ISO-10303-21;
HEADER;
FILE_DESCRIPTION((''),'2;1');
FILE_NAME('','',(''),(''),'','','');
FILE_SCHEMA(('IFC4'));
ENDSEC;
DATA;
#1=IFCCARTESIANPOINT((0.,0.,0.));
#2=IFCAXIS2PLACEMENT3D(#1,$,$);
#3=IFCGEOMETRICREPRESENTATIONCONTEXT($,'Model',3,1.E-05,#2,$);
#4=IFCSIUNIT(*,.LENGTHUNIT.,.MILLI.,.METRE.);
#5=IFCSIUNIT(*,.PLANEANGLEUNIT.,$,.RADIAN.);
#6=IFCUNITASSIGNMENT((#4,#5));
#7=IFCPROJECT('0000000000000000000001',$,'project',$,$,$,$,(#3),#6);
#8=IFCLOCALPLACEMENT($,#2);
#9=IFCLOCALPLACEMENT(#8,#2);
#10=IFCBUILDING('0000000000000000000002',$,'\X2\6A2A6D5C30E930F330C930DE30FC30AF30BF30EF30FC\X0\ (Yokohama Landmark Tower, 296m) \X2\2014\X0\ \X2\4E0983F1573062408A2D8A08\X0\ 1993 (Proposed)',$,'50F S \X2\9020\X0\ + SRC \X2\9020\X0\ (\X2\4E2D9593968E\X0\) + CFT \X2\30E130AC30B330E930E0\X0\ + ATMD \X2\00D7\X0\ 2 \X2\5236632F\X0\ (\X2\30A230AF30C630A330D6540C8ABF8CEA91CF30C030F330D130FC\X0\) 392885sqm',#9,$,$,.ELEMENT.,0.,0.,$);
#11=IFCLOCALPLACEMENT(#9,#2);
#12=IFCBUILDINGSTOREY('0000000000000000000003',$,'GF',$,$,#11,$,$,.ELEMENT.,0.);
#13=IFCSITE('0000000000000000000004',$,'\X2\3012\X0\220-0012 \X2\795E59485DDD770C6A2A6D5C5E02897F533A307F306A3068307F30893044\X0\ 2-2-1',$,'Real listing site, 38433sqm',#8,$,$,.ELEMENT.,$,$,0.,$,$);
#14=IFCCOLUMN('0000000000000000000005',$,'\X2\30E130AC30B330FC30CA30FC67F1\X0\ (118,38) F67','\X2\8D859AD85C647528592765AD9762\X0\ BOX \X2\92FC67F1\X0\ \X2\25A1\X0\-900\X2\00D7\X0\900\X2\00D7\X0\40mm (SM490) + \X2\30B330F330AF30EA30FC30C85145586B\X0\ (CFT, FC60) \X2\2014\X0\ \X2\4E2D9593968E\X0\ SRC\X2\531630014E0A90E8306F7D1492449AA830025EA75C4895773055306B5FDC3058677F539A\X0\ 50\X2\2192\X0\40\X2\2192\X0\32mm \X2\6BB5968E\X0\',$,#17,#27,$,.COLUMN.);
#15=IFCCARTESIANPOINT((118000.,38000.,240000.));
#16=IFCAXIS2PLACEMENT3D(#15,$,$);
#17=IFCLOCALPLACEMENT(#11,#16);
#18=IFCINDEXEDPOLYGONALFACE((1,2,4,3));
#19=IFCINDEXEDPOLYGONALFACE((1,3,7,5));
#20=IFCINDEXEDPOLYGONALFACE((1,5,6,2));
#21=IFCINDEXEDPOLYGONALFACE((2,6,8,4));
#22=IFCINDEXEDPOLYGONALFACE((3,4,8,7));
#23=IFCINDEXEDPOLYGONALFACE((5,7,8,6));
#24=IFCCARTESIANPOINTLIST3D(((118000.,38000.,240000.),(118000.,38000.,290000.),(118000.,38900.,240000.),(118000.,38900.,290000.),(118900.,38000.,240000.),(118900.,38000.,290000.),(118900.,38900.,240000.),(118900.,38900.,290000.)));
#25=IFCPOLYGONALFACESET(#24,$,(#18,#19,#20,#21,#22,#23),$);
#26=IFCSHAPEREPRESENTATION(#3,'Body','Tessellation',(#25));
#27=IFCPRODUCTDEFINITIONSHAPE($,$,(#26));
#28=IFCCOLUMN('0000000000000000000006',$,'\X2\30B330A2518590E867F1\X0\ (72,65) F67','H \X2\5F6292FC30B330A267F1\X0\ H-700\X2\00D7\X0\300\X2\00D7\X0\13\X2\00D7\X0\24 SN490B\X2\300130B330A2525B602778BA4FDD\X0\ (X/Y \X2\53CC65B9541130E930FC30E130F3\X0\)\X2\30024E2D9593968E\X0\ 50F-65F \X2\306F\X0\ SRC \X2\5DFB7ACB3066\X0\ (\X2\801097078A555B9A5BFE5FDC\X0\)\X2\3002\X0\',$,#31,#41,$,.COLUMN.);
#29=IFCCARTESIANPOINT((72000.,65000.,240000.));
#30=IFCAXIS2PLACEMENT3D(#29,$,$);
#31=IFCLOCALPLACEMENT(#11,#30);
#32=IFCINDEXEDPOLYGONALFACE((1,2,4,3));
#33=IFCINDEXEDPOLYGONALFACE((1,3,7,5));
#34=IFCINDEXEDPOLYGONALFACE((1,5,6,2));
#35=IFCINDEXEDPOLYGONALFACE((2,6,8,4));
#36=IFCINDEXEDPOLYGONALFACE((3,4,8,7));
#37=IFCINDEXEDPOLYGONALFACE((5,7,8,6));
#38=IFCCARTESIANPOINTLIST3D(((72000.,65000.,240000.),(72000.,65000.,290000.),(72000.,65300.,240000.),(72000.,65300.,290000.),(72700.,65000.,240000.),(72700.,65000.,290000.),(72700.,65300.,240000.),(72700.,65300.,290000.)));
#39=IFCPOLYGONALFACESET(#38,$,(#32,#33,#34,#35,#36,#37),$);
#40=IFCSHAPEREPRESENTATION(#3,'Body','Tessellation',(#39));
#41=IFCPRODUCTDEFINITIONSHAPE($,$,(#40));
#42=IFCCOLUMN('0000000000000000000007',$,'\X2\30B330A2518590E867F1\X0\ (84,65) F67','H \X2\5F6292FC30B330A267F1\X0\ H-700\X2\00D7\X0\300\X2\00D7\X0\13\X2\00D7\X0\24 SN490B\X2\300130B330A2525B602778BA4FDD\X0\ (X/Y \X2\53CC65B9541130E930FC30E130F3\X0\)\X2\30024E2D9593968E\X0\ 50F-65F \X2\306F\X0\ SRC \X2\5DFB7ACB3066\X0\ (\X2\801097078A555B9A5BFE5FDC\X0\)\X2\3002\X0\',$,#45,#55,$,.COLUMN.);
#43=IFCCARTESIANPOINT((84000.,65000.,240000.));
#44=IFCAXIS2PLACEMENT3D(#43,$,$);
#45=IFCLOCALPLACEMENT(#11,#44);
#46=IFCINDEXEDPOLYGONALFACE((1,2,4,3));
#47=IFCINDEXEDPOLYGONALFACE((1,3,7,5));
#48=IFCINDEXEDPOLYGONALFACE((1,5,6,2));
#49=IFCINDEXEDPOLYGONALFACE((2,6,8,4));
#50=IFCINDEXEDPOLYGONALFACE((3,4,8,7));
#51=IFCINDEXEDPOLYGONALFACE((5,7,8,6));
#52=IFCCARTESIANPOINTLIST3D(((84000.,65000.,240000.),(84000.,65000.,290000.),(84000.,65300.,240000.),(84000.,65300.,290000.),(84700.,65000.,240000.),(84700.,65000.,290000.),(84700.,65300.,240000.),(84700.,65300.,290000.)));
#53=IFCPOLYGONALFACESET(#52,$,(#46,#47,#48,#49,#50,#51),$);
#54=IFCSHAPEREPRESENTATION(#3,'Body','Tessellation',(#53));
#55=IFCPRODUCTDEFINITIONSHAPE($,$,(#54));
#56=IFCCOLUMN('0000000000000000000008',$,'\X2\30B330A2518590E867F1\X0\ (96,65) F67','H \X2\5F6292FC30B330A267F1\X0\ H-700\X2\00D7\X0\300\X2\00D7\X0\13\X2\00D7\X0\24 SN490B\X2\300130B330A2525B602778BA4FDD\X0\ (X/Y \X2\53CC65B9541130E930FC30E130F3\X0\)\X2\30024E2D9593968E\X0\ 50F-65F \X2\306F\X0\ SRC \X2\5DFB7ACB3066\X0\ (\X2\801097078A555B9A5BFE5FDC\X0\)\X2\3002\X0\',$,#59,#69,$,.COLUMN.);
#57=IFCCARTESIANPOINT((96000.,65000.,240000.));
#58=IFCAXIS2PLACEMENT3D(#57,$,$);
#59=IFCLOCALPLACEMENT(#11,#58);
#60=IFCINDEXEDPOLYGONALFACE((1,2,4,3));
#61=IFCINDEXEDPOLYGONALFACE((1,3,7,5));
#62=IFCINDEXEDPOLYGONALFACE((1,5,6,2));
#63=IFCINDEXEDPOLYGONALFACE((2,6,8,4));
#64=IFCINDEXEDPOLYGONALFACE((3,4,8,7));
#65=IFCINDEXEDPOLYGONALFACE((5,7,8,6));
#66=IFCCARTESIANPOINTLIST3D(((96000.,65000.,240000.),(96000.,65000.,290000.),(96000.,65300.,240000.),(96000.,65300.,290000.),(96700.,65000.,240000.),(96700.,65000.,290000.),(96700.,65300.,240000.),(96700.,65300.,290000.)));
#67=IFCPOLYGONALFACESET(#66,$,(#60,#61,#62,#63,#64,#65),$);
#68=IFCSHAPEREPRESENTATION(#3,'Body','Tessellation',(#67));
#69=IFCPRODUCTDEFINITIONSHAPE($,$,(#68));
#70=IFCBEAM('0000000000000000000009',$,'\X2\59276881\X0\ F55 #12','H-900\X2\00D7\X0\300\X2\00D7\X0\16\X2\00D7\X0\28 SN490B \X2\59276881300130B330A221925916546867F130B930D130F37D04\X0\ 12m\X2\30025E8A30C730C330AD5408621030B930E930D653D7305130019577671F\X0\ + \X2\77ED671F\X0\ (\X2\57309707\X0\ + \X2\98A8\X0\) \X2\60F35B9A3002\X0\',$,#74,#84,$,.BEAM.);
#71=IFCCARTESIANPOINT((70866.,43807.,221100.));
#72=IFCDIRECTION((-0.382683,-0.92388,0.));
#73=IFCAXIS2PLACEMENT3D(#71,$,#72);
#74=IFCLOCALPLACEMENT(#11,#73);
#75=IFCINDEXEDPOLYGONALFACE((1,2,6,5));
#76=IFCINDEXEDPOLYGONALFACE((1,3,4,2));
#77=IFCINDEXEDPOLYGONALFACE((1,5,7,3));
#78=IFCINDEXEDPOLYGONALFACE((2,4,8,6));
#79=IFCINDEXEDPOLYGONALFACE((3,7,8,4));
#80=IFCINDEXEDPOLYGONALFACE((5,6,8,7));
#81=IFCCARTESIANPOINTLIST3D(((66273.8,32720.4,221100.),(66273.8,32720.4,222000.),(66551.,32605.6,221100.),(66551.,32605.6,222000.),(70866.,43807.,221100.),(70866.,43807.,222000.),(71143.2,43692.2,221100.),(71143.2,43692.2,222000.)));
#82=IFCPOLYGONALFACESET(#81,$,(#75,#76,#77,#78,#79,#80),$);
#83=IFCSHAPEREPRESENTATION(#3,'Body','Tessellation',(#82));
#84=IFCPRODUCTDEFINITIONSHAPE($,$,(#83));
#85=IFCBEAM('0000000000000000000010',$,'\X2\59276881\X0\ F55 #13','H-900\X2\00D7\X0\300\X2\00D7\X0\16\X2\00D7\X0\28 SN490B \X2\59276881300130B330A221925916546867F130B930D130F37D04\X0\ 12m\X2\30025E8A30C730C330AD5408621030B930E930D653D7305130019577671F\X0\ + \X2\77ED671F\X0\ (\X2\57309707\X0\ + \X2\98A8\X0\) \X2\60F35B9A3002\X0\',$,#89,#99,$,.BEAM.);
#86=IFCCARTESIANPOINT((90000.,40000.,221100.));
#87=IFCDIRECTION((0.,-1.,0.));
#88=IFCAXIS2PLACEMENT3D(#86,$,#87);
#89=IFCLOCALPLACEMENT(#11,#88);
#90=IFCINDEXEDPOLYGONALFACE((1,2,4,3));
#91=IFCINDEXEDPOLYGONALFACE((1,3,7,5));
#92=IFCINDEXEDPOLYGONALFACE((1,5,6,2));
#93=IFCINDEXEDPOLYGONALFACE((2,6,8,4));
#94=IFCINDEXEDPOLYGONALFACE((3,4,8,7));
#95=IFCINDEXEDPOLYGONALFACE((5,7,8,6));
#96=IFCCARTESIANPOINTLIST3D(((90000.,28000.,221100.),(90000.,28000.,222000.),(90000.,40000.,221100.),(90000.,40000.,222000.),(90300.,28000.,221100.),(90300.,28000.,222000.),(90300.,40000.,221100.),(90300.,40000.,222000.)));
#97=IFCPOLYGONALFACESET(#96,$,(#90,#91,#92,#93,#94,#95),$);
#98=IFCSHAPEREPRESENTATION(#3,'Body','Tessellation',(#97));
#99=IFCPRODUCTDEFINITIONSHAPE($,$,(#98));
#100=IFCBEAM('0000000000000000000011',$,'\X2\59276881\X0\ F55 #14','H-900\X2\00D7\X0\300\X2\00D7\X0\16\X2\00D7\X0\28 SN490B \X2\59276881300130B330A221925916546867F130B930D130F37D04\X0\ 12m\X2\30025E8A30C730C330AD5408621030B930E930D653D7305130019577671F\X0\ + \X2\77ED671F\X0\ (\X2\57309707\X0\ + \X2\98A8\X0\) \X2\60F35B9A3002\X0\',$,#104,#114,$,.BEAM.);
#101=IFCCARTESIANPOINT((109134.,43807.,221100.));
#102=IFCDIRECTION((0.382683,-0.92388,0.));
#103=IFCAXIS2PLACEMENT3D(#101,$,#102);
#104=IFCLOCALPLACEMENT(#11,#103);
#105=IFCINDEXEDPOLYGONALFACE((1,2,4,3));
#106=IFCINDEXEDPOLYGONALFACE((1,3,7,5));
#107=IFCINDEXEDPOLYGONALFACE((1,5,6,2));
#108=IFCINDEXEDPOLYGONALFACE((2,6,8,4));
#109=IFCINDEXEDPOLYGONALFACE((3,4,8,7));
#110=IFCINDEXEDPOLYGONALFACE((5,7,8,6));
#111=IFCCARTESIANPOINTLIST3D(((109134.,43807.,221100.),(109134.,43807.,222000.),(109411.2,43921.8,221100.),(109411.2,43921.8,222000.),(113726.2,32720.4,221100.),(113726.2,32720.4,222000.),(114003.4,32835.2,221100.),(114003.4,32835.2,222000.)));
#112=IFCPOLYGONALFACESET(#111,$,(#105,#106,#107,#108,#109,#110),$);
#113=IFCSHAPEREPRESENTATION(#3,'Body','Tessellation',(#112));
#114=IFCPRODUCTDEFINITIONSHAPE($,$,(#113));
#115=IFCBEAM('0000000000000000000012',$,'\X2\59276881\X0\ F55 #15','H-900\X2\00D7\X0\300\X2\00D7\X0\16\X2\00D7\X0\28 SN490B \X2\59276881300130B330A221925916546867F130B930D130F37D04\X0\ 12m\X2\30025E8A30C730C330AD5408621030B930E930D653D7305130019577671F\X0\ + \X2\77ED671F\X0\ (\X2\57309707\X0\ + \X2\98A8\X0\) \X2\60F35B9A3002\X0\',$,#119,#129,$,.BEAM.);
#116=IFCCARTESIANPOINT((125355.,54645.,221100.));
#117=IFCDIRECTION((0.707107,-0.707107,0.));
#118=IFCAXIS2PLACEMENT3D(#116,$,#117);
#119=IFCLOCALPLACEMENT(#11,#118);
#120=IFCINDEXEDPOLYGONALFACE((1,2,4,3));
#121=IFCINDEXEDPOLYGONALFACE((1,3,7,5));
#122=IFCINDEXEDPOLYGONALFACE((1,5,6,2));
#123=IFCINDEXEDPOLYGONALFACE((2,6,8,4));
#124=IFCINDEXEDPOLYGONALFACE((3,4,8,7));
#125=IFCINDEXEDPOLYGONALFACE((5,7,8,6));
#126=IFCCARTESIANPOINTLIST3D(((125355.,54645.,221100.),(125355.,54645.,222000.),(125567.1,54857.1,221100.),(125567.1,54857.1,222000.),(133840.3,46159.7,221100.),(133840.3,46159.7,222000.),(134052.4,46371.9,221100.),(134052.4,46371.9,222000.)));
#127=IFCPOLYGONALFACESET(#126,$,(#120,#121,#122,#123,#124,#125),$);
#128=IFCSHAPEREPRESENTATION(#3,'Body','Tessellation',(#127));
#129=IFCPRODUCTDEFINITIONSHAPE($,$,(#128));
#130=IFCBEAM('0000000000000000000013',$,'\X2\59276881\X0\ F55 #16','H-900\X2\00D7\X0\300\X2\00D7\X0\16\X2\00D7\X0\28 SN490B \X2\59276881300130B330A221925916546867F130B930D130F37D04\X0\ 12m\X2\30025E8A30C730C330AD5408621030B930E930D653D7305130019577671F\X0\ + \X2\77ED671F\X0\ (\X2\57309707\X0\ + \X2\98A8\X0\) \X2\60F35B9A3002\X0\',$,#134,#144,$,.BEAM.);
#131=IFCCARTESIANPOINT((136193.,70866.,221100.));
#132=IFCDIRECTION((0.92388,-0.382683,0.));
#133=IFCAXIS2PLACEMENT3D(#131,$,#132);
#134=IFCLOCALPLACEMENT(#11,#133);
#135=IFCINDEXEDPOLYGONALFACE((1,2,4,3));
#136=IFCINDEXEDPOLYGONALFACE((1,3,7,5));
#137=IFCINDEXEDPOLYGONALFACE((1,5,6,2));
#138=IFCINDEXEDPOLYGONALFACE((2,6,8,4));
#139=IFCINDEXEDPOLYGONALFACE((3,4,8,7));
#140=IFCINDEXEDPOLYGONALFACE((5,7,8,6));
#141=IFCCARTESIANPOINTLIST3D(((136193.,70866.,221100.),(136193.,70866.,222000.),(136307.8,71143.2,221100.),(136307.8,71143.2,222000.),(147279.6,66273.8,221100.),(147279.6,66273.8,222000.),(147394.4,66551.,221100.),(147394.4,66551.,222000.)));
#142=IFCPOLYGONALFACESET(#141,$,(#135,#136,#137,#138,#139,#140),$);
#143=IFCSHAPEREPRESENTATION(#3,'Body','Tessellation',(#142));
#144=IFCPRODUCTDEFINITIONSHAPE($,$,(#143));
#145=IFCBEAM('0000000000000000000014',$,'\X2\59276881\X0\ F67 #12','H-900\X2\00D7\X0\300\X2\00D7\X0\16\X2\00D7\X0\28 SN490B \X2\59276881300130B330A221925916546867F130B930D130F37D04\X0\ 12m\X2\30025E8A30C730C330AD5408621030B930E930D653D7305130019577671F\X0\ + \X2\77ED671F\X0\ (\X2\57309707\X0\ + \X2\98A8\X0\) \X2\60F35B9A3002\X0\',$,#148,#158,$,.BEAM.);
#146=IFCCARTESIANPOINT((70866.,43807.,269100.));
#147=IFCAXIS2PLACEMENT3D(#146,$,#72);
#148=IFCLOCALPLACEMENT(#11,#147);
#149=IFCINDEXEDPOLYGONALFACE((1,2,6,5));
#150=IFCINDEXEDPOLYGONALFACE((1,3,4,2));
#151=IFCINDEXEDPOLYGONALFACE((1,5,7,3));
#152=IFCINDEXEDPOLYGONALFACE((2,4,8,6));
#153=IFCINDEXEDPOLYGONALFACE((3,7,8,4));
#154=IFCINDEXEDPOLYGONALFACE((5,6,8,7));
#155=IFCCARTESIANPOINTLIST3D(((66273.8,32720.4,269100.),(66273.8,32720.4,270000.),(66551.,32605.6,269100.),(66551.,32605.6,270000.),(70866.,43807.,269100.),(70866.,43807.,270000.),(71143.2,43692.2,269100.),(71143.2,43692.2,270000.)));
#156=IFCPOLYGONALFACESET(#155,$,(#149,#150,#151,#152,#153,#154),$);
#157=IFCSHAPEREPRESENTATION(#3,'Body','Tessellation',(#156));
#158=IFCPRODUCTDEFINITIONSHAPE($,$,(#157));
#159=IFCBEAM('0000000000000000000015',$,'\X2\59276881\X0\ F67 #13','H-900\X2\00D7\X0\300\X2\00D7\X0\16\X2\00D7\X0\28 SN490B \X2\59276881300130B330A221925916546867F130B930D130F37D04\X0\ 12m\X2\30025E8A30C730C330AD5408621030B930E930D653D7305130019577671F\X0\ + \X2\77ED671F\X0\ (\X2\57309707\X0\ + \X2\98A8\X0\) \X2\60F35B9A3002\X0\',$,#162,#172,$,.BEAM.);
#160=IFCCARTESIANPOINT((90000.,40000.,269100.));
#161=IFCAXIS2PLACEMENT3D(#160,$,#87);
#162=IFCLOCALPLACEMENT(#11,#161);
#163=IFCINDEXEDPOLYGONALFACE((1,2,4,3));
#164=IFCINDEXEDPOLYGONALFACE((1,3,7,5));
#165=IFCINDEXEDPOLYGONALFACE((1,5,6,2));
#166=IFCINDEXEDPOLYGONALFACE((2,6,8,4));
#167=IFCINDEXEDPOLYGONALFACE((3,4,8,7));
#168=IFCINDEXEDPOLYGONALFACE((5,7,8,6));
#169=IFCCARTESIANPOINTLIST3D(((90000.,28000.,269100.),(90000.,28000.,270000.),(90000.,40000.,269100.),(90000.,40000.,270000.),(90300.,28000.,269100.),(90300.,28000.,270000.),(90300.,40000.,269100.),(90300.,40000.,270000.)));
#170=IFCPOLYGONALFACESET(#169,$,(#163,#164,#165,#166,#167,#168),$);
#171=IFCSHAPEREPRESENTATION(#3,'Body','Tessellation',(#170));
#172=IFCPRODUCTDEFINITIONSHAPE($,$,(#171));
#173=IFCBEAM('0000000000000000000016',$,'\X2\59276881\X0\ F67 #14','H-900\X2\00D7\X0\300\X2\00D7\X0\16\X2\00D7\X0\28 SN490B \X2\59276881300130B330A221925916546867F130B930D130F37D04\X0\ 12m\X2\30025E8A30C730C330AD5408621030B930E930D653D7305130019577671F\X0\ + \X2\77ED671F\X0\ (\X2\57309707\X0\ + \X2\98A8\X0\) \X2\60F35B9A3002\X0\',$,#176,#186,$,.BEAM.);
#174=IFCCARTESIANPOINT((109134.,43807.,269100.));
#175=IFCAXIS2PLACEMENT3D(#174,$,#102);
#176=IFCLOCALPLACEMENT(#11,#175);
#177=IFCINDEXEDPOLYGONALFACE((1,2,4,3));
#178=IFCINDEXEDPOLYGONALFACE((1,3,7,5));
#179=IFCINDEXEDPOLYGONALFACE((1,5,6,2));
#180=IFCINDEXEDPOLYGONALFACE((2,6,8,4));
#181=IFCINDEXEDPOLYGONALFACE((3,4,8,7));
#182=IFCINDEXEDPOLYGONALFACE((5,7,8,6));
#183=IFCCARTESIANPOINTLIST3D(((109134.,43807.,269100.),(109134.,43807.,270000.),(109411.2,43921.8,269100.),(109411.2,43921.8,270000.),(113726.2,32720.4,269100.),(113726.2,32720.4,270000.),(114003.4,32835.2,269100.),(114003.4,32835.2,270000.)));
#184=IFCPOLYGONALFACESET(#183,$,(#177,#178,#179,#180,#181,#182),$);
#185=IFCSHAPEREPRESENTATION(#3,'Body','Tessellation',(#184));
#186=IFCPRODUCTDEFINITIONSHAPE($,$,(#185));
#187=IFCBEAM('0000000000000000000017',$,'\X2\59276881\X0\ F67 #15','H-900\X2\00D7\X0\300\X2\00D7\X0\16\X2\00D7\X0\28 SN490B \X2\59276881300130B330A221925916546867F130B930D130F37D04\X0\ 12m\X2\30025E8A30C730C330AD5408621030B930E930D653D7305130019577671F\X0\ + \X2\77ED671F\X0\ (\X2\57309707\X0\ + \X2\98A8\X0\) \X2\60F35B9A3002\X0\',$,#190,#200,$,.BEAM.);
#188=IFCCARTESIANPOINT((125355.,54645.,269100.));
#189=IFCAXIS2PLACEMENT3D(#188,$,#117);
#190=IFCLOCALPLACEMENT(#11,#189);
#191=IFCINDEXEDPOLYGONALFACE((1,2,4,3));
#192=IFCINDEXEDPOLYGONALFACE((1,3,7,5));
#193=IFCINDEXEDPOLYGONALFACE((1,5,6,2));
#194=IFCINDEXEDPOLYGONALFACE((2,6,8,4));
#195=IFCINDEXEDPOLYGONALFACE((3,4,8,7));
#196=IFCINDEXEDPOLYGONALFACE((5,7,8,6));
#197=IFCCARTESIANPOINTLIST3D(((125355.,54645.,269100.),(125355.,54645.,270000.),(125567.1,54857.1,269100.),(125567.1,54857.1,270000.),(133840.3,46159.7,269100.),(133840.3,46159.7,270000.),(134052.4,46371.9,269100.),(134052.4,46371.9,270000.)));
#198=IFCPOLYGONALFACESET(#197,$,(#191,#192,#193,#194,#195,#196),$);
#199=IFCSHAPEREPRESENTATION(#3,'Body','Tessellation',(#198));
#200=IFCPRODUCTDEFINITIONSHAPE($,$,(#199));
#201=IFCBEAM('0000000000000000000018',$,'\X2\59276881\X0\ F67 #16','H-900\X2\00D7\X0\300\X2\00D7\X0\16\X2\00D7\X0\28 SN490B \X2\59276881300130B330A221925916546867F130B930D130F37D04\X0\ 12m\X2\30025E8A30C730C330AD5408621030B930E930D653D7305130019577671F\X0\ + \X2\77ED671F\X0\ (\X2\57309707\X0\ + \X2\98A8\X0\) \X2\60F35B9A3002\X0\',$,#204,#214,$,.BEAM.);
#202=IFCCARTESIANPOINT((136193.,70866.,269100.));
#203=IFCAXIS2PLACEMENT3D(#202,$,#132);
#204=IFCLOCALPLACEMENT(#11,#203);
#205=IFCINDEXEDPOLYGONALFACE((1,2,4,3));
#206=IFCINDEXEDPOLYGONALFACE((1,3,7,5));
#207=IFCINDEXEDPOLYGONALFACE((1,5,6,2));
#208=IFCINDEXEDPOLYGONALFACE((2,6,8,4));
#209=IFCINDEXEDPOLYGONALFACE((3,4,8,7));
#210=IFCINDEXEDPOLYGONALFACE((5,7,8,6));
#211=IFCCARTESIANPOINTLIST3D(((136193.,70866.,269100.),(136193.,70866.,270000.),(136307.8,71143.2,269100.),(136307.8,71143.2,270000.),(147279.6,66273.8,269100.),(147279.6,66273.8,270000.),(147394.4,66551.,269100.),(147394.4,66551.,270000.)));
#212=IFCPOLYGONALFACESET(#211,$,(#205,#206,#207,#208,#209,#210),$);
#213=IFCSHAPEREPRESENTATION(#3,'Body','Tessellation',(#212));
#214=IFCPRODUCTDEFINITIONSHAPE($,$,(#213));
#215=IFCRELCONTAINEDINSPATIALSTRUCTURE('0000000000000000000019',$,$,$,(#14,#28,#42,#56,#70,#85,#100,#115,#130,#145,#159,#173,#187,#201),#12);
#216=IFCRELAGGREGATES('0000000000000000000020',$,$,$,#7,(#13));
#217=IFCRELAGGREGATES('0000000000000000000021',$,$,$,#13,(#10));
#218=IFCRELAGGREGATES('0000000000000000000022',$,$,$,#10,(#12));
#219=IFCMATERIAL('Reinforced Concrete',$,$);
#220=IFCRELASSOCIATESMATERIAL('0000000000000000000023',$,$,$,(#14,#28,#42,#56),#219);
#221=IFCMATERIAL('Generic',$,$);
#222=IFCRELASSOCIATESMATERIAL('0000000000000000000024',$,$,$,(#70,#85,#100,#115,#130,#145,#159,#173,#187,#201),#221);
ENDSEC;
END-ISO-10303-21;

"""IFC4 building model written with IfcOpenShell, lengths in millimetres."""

from ifc_helpers import new_model, si_unit, frame, frame_2d, origin, place, context, project, spatial, rectangle, extrude, material, element, save


model = new_model("IFC4")

# Units and contexts
model_context = context("Model", 3, precision=1e-05, world=origin())
ifc_project = project(units=[si_unit("LENGTHUNIT", "METRE", prefix="MILLI"), si_unit("PLANEANGLEUNIT", "RADIAN")], contexts=[model_context])

# Site, building, storey
site_placement = place(None, origin())
site = spatial("IfcSite", under=ifc_project, at=site_placement, Name="〒220-0012 神奈川県横浜市西区みなとみらい 2-2-1", ObjectType="Real listing site, 38433sqm", CompositionType="ELEMENT", RefElevation=0.0)
building_placement = place(site_placement, origin())
building = spatial("IfcBuilding", under=site, at=building_placement, Name="横浜ランドマークタワー (Yokohama Landmark Tower, 296m) — 三菱地所設計 1993 (Proposed)", ObjectType="50F S 造 + SRC 造 (中間階) + CFT メガコラム + ATMD × 2 制振 (アクティブ同調質量ダンパー) 392885sqm", CompositionType="ELEMENT", ElevationOfRefHeight=0.0, ElevationOfTerrain=0.0)
storey_placement = place(building_placement, origin())
storey = spatial("IfcBuildingStorey", under=building, at=storey_placement, Name="GF", CompositionType="ELEMENT", Elevation=0.0)

# Columns
ifc_material_1 = material(Name="Reinforced Concrete")
column_1_placement = place(storey_placement, frame((118000.0, 38000.0, 240000.0)))
element("IfcColumn", 1, at=column_1_placement, inside=storey, material=ifc_material_1, Name="メガコーナー柱 (118,38) F67", Description="超高層用大断面 BOX 鋼柱 □-900×900×40mm (SM490) + コンクリート充填 (CFT, FC60) — 中間階 SRC化、上部は純鉄骨。座屈長さに応じ板厚 50→40→32mm 段階", PredefinedType="COLUMN", context=model_context, shape_type="SweptSolid", body=[
    extrude(rectangle(XDim=900.0, YDim=900.0, at=frame_2d((450.0, 450.0))), frame((118000.0, 38000.0, 240000.0)), (0.0, 0.0, 1.0), 50000.0),
])
column_2_placement = place(storey_placement, frame((72000.0, 65000.0, 240000.0)))
element("IfcColumn", 2, at=column_2_placement, inside=storey, material=ifc_material_1, Name="コア内部柱 (72,65) F67", Description="H 形鋼コア柱 H-700×300×13×24 SN490B、コア剛性確保 (X/Y 双方向ラーメン)。中間階 50F-65F は SRC 巻立て (耐震評定対応)。", PredefinedType="COLUMN", context=model_context, shape_type="SweptSolid", body=[
    extrude(rectangle(XDim=700.0, YDim=300.0, at=frame_2d((350.0, 150.0))), frame((72000.0, 65000.0, 240000.0)), (0.0, 0.0, 1.0), 50000.0),
])
column_3_placement = place(storey_placement, frame((84000.0, 65000.0, 240000.0)))
element("IfcColumn", 3, at=column_3_placement, inside=storey, material=ifc_material_1, Name="コア内部柱 (84,65) F67", Description="H 形鋼コア柱 H-700×300×13×24 SN490B、コア剛性確保 (X/Y 双方向ラーメン)。中間階 50F-65F は SRC 巻立て (耐震評定対応)。", PredefinedType="COLUMN", context=model_context, shape_type="SweptSolid", body=[
    extrude(rectangle(XDim=700.0, YDim=300.0, at=frame_2d((350.0, 150.0))), frame((84000.0, 65000.0, 240000.0)), (0.0, 0.0, 1.0), 50000.0),
])
column_4_placement = place(storey_placement, frame((96000.0, 65000.0, 240000.0)))
element("IfcColumn", 4, at=column_4_placement, inside=storey, material=ifc_material_1, Name="コア内部柱 (96,65) F67", Description="H 形鋼コア柱 H-700×300×13×24 SN490B、コア剛性確保 (X/Y 双方向ラーメン)。中間階 50F-65F は SRC 巻立て (耐震評定対応)。", PredefinedType="COLUMN", context=model_context, shape_type="SweptSolid", body=[
    extrude(rectangle(XDim=700.0, YDim=300.0, at=frame_2d((350.0, 150.0))), frame((96000.0, 65000.0, 240000.0)), (0.0, 0.0, 1.0), 50000.0),
])

# Beams
ifc_material_2 = material(Name="Generic")
beam_1_placement = place(storey_placement, frame((70866.0, 43807.0, 221100.0), x_axis=(-0.382683, -0.92388, 0.0)))
element("IfcBeam", 5, at=beam_1_placement, inside=storey, material=ifc_material_2, Name="大梁 F55 #12", Description="H-900×300×16×28 SN490B 大梁、コア→外周柱スパン約 12m。床デッキ合成スラブ受け、長期 + 短期 (地震 + 風) 想定。", PredefinedType="BEAM", context=model_context, shape_type="SweptSolid", body=[
    extrude(rectangle(XDim=12000.0, YDim=300.0, at=frame_2d((6000.0, 150.0))), frame((70866.0, 43807.0, 221100.0), x_axis=(-0.382683, -0.92388, 0.0)), (0.0, 0.0, 1.0), 900.0),
])
beam_2_placement = place(storey_placement, frame((90000.0, 40000.0, 221100.0), x_axis=(0.0, -1.0, 0.0)))
element("IfcBeam", 6, at=beam_2_placement, inside=storey, material=ifc_material_2, Name="大梁 F55 #13", Description="H-900×300×16×28 SN490B 大梁、コア→外周柱スパン約 12m。床デッキ合成スラブ受け、長期 + 短期 (地震 + 風) 想定。", PredefinedType="BEAM", context=model_context, shape_type="SweptSolid", body=[
    extrude(rectangle(XDim=12000.0, YDim=300.0, at=frame_2d((6000.0, 150.0))), frame((90000.0, 40000.0, 221100.0), x_axis=(0.0, -1.0, 0.0)), (0.0, 0.0, 1.0), 900.0),
])
beam_3_placement = place(storey_placement, frame((109134.0, 43807.0, 221100.0), x_axis=(0.382683, -0.92388, 0.0)))
element("IfcBeam", 7, at=beam_3_placement, inside=storey, material=ifc_material_2, Name="大梁 F55 #14", Description="H-900×300×16×28 SN490B 大梁、コア→外周柱スパン約 12m。床デッキ合成スラブ受け、長期 + 短期 (地震 + 風) 想定。", PredefinedType="BEAM", context=model_context, shape_type="SweptSolid", body=[
    extrude(rectangle(XDim=12000.0, YDim=300.0, at=frame_2d((6000.0, 150.0))), frame((109134.0, 43807.0, 221100.0), x_axis=(0.382683, -0.92388, 0.0)), (0.0, 0.0, 1.0), 900.0),
])
beam_4_placement = place(storey_placement, frame((125355.0, 54645.0, 221100.0), x_axis=(0.707107, -0.707107, 0.0)))
element("IfcBeam", 8, at=beam_4_placement, inside=storey, material=ifc_material_2, Name="大梁 F55 #15", Description="H-900×300×16×28 SN490B 大梁、コア→外周柱スパン約 12m。床デッキ合成スラブ受け、長期 + 短期 (地震 + 風) 想定。", PredefinedType="BEAM", context=model_context, shape_type="SweptSolid", body=[
    extrude(rectangle(XDim=12000.0, YDim=300.0, at=frame_2d((6000.0, 150.0))), frame((125355.0, 54645.0, 221100.0), x_axis=(0.707107, -0.707107, 0.0)), (0.0, 0.0, 1.0), 900.0),
])
beam_5_placement = place(storey_placement, frame((136193.0, 70866.0, 221100.0), x_axis=(0.92388, -0.382683, 0.0)))
element("IfcBeam", 9, at=beam_5_placement, inside=storey, material=ifc_material_2, Name="大梁 F55 #16", Description="H-900×300×16×28 SN490B 大梁、コア→外周柱スパン約 12m。床デッキ合成スラブ受け、長期 + 短期 (地震 + 風) 想定。", PredefinedType="BEAM", context=model_context, shape_type="SweptSolid", body=[
    extrude(rectangle(XDim=12000.0, YDim=300.0, at=frame_2d((6000.0, 150.0))), frame((136193.0, 70866.0, 221100.0), x_axis=(0.92388, -0.382683, 0.0)), (0.0, 0.0, 1.0), 900.0),
])
beam_6_placement = place(storey_placement, frame((70866.0, 43807.0, 269100.0), x_axis=(-0.382683, -0.92388, 0.0)))
element("IfcBeam", 10, at=beam_6_placement, inside=storey, material=ifc_material_2, Name="大梁 F67 #12", Description="H-900×300×16×28 SN490B 大梁、コア→外周柱スパン約 12m。床デッキ合成スラブ受け、長期 + 短期 (地震 + 風) 想定。", PredefinedType="BEAM", context=model_context, shape_type="SweptSolid", body=[
    extrude(rectangle(XDim=12000.0, YDim=300.0, at=frame_2d((6000.0, 150.0))), frame((70866.0, 43807.0, 269100.0), x_axis=(-0.382683, -0.92388, 0.0)), (0.0, 0.0, 1.0), 900.0),
])
beam_7_placement = place(storey_placement, frame((90000.0, 40000.0, 269100.0), x_axis=(0.0, -1.0, 0.0)))
element("IfcBeam", 11, at=beam_7_placement, inside=storey, material=ifc_material_2, Name="大梁 F67 #13", Description="H-900×300×16×28 SN490B 大梁、コア→外周柱スパン約 12m。床デッキ合成スラブ受け、長期 + 短期 (地震 + 風) 想定。", PredefinedType="BEAM", context=model_context, shape_type="SweptSolid", body=[
    extrude(rectangle(XDim=12000.0, YDim=300.0, at=frame_2d((6000.0, 150.0))), frame((90000.0, 40000.0, 269100.0), x_axis=(0.0, -1.0, 0.0)), (0.0, 0.0, 1.0), 900.0),
])
beam_8_placement = place(storey_placement, frame((109134.0, 43807.0, 269100.0), x_axis=(0.382683, -0.92388, 0.0)))
element("IfcBeam", 12, at=beam_8_placement, inside=storey, material=ifc_material_2, Name="大梁 F67 #14", Description="H-900×300×16×28 SN490B 大梁、コア→外周柱スパン約 12m。床デッキ合成スラブ受け、長期 + 短期 (地震 + 風) 想定。", PredefinedType="BEAM", context=model_context, shape_type="SweptSolid", body=[
    extrude(rectangle(XDim=12000.0, YDim=300.0, at=frame_2d((6000.0, 150.0))), frame((109134.0, 43807.0, 269100.0), x_axis=(0.382683, -0.92388, 0.0)), (0.0, 0.0, 1.0), 900.0),
])
beam_9_placement = place(storey_placement, frame((125355.0, 54645.0, 269100.0), x_axis=(0.707107, -0.707107, 0.0)))
element("IfcBeam", 13, at=beam_9_placement, inside=storey, material=ifc_material_2, Name="大梁 F67 #15", Description="H-900×300×16×28 SN490B 大梁、コア→外周柱スパン約 12m。床デッキ合成スラブ受け、長期 + 短期 (地震 + 風) 想定。", PredefinedType="BEAM", context=model_context, shape_type="SweptSolid", body=[
    extrude(rectangle(XDim=12000.0, YDim=300.0, at=frame_2d((6000.0, 150.0))), frame((125355.0, 54645.0, 269100.0), x_axis=(0.707107, -0.707107, 0.0)), (0.0, 0.0, 1.0), 900.0),
])
beam_10_placement = place(storey_placement, frame((136193.0, 70866.0, 269100.0), x_axis=(0.92388, -0.382683, 0.0)))
element("IfcBeam", 14, at=beam_10_placement, inside=storey, material=ifc_material_2, Name="大梁 F67 #16", Description="H-900×300×16×28 SN490B 大梁、コア→外周柱スパン約 12m。床デッキ合成スラブ受け、長期 + 短期 (地震 + 風) 想定。", PredefinedType="BEAM", context=model_context, shape_type="SweptSolid", body=[
    extrude(rectangle(XDim=12000.0, YDim=300.0, at=frame_2d((6000.0, 150.0))), frame((136193.0, 70866.0, 269100.0), x_axis=(0.92388, -0.382683, 0.0)), (0.0, 0.0, 1.0), 900.0),
])

save(model, "model.ifc")
